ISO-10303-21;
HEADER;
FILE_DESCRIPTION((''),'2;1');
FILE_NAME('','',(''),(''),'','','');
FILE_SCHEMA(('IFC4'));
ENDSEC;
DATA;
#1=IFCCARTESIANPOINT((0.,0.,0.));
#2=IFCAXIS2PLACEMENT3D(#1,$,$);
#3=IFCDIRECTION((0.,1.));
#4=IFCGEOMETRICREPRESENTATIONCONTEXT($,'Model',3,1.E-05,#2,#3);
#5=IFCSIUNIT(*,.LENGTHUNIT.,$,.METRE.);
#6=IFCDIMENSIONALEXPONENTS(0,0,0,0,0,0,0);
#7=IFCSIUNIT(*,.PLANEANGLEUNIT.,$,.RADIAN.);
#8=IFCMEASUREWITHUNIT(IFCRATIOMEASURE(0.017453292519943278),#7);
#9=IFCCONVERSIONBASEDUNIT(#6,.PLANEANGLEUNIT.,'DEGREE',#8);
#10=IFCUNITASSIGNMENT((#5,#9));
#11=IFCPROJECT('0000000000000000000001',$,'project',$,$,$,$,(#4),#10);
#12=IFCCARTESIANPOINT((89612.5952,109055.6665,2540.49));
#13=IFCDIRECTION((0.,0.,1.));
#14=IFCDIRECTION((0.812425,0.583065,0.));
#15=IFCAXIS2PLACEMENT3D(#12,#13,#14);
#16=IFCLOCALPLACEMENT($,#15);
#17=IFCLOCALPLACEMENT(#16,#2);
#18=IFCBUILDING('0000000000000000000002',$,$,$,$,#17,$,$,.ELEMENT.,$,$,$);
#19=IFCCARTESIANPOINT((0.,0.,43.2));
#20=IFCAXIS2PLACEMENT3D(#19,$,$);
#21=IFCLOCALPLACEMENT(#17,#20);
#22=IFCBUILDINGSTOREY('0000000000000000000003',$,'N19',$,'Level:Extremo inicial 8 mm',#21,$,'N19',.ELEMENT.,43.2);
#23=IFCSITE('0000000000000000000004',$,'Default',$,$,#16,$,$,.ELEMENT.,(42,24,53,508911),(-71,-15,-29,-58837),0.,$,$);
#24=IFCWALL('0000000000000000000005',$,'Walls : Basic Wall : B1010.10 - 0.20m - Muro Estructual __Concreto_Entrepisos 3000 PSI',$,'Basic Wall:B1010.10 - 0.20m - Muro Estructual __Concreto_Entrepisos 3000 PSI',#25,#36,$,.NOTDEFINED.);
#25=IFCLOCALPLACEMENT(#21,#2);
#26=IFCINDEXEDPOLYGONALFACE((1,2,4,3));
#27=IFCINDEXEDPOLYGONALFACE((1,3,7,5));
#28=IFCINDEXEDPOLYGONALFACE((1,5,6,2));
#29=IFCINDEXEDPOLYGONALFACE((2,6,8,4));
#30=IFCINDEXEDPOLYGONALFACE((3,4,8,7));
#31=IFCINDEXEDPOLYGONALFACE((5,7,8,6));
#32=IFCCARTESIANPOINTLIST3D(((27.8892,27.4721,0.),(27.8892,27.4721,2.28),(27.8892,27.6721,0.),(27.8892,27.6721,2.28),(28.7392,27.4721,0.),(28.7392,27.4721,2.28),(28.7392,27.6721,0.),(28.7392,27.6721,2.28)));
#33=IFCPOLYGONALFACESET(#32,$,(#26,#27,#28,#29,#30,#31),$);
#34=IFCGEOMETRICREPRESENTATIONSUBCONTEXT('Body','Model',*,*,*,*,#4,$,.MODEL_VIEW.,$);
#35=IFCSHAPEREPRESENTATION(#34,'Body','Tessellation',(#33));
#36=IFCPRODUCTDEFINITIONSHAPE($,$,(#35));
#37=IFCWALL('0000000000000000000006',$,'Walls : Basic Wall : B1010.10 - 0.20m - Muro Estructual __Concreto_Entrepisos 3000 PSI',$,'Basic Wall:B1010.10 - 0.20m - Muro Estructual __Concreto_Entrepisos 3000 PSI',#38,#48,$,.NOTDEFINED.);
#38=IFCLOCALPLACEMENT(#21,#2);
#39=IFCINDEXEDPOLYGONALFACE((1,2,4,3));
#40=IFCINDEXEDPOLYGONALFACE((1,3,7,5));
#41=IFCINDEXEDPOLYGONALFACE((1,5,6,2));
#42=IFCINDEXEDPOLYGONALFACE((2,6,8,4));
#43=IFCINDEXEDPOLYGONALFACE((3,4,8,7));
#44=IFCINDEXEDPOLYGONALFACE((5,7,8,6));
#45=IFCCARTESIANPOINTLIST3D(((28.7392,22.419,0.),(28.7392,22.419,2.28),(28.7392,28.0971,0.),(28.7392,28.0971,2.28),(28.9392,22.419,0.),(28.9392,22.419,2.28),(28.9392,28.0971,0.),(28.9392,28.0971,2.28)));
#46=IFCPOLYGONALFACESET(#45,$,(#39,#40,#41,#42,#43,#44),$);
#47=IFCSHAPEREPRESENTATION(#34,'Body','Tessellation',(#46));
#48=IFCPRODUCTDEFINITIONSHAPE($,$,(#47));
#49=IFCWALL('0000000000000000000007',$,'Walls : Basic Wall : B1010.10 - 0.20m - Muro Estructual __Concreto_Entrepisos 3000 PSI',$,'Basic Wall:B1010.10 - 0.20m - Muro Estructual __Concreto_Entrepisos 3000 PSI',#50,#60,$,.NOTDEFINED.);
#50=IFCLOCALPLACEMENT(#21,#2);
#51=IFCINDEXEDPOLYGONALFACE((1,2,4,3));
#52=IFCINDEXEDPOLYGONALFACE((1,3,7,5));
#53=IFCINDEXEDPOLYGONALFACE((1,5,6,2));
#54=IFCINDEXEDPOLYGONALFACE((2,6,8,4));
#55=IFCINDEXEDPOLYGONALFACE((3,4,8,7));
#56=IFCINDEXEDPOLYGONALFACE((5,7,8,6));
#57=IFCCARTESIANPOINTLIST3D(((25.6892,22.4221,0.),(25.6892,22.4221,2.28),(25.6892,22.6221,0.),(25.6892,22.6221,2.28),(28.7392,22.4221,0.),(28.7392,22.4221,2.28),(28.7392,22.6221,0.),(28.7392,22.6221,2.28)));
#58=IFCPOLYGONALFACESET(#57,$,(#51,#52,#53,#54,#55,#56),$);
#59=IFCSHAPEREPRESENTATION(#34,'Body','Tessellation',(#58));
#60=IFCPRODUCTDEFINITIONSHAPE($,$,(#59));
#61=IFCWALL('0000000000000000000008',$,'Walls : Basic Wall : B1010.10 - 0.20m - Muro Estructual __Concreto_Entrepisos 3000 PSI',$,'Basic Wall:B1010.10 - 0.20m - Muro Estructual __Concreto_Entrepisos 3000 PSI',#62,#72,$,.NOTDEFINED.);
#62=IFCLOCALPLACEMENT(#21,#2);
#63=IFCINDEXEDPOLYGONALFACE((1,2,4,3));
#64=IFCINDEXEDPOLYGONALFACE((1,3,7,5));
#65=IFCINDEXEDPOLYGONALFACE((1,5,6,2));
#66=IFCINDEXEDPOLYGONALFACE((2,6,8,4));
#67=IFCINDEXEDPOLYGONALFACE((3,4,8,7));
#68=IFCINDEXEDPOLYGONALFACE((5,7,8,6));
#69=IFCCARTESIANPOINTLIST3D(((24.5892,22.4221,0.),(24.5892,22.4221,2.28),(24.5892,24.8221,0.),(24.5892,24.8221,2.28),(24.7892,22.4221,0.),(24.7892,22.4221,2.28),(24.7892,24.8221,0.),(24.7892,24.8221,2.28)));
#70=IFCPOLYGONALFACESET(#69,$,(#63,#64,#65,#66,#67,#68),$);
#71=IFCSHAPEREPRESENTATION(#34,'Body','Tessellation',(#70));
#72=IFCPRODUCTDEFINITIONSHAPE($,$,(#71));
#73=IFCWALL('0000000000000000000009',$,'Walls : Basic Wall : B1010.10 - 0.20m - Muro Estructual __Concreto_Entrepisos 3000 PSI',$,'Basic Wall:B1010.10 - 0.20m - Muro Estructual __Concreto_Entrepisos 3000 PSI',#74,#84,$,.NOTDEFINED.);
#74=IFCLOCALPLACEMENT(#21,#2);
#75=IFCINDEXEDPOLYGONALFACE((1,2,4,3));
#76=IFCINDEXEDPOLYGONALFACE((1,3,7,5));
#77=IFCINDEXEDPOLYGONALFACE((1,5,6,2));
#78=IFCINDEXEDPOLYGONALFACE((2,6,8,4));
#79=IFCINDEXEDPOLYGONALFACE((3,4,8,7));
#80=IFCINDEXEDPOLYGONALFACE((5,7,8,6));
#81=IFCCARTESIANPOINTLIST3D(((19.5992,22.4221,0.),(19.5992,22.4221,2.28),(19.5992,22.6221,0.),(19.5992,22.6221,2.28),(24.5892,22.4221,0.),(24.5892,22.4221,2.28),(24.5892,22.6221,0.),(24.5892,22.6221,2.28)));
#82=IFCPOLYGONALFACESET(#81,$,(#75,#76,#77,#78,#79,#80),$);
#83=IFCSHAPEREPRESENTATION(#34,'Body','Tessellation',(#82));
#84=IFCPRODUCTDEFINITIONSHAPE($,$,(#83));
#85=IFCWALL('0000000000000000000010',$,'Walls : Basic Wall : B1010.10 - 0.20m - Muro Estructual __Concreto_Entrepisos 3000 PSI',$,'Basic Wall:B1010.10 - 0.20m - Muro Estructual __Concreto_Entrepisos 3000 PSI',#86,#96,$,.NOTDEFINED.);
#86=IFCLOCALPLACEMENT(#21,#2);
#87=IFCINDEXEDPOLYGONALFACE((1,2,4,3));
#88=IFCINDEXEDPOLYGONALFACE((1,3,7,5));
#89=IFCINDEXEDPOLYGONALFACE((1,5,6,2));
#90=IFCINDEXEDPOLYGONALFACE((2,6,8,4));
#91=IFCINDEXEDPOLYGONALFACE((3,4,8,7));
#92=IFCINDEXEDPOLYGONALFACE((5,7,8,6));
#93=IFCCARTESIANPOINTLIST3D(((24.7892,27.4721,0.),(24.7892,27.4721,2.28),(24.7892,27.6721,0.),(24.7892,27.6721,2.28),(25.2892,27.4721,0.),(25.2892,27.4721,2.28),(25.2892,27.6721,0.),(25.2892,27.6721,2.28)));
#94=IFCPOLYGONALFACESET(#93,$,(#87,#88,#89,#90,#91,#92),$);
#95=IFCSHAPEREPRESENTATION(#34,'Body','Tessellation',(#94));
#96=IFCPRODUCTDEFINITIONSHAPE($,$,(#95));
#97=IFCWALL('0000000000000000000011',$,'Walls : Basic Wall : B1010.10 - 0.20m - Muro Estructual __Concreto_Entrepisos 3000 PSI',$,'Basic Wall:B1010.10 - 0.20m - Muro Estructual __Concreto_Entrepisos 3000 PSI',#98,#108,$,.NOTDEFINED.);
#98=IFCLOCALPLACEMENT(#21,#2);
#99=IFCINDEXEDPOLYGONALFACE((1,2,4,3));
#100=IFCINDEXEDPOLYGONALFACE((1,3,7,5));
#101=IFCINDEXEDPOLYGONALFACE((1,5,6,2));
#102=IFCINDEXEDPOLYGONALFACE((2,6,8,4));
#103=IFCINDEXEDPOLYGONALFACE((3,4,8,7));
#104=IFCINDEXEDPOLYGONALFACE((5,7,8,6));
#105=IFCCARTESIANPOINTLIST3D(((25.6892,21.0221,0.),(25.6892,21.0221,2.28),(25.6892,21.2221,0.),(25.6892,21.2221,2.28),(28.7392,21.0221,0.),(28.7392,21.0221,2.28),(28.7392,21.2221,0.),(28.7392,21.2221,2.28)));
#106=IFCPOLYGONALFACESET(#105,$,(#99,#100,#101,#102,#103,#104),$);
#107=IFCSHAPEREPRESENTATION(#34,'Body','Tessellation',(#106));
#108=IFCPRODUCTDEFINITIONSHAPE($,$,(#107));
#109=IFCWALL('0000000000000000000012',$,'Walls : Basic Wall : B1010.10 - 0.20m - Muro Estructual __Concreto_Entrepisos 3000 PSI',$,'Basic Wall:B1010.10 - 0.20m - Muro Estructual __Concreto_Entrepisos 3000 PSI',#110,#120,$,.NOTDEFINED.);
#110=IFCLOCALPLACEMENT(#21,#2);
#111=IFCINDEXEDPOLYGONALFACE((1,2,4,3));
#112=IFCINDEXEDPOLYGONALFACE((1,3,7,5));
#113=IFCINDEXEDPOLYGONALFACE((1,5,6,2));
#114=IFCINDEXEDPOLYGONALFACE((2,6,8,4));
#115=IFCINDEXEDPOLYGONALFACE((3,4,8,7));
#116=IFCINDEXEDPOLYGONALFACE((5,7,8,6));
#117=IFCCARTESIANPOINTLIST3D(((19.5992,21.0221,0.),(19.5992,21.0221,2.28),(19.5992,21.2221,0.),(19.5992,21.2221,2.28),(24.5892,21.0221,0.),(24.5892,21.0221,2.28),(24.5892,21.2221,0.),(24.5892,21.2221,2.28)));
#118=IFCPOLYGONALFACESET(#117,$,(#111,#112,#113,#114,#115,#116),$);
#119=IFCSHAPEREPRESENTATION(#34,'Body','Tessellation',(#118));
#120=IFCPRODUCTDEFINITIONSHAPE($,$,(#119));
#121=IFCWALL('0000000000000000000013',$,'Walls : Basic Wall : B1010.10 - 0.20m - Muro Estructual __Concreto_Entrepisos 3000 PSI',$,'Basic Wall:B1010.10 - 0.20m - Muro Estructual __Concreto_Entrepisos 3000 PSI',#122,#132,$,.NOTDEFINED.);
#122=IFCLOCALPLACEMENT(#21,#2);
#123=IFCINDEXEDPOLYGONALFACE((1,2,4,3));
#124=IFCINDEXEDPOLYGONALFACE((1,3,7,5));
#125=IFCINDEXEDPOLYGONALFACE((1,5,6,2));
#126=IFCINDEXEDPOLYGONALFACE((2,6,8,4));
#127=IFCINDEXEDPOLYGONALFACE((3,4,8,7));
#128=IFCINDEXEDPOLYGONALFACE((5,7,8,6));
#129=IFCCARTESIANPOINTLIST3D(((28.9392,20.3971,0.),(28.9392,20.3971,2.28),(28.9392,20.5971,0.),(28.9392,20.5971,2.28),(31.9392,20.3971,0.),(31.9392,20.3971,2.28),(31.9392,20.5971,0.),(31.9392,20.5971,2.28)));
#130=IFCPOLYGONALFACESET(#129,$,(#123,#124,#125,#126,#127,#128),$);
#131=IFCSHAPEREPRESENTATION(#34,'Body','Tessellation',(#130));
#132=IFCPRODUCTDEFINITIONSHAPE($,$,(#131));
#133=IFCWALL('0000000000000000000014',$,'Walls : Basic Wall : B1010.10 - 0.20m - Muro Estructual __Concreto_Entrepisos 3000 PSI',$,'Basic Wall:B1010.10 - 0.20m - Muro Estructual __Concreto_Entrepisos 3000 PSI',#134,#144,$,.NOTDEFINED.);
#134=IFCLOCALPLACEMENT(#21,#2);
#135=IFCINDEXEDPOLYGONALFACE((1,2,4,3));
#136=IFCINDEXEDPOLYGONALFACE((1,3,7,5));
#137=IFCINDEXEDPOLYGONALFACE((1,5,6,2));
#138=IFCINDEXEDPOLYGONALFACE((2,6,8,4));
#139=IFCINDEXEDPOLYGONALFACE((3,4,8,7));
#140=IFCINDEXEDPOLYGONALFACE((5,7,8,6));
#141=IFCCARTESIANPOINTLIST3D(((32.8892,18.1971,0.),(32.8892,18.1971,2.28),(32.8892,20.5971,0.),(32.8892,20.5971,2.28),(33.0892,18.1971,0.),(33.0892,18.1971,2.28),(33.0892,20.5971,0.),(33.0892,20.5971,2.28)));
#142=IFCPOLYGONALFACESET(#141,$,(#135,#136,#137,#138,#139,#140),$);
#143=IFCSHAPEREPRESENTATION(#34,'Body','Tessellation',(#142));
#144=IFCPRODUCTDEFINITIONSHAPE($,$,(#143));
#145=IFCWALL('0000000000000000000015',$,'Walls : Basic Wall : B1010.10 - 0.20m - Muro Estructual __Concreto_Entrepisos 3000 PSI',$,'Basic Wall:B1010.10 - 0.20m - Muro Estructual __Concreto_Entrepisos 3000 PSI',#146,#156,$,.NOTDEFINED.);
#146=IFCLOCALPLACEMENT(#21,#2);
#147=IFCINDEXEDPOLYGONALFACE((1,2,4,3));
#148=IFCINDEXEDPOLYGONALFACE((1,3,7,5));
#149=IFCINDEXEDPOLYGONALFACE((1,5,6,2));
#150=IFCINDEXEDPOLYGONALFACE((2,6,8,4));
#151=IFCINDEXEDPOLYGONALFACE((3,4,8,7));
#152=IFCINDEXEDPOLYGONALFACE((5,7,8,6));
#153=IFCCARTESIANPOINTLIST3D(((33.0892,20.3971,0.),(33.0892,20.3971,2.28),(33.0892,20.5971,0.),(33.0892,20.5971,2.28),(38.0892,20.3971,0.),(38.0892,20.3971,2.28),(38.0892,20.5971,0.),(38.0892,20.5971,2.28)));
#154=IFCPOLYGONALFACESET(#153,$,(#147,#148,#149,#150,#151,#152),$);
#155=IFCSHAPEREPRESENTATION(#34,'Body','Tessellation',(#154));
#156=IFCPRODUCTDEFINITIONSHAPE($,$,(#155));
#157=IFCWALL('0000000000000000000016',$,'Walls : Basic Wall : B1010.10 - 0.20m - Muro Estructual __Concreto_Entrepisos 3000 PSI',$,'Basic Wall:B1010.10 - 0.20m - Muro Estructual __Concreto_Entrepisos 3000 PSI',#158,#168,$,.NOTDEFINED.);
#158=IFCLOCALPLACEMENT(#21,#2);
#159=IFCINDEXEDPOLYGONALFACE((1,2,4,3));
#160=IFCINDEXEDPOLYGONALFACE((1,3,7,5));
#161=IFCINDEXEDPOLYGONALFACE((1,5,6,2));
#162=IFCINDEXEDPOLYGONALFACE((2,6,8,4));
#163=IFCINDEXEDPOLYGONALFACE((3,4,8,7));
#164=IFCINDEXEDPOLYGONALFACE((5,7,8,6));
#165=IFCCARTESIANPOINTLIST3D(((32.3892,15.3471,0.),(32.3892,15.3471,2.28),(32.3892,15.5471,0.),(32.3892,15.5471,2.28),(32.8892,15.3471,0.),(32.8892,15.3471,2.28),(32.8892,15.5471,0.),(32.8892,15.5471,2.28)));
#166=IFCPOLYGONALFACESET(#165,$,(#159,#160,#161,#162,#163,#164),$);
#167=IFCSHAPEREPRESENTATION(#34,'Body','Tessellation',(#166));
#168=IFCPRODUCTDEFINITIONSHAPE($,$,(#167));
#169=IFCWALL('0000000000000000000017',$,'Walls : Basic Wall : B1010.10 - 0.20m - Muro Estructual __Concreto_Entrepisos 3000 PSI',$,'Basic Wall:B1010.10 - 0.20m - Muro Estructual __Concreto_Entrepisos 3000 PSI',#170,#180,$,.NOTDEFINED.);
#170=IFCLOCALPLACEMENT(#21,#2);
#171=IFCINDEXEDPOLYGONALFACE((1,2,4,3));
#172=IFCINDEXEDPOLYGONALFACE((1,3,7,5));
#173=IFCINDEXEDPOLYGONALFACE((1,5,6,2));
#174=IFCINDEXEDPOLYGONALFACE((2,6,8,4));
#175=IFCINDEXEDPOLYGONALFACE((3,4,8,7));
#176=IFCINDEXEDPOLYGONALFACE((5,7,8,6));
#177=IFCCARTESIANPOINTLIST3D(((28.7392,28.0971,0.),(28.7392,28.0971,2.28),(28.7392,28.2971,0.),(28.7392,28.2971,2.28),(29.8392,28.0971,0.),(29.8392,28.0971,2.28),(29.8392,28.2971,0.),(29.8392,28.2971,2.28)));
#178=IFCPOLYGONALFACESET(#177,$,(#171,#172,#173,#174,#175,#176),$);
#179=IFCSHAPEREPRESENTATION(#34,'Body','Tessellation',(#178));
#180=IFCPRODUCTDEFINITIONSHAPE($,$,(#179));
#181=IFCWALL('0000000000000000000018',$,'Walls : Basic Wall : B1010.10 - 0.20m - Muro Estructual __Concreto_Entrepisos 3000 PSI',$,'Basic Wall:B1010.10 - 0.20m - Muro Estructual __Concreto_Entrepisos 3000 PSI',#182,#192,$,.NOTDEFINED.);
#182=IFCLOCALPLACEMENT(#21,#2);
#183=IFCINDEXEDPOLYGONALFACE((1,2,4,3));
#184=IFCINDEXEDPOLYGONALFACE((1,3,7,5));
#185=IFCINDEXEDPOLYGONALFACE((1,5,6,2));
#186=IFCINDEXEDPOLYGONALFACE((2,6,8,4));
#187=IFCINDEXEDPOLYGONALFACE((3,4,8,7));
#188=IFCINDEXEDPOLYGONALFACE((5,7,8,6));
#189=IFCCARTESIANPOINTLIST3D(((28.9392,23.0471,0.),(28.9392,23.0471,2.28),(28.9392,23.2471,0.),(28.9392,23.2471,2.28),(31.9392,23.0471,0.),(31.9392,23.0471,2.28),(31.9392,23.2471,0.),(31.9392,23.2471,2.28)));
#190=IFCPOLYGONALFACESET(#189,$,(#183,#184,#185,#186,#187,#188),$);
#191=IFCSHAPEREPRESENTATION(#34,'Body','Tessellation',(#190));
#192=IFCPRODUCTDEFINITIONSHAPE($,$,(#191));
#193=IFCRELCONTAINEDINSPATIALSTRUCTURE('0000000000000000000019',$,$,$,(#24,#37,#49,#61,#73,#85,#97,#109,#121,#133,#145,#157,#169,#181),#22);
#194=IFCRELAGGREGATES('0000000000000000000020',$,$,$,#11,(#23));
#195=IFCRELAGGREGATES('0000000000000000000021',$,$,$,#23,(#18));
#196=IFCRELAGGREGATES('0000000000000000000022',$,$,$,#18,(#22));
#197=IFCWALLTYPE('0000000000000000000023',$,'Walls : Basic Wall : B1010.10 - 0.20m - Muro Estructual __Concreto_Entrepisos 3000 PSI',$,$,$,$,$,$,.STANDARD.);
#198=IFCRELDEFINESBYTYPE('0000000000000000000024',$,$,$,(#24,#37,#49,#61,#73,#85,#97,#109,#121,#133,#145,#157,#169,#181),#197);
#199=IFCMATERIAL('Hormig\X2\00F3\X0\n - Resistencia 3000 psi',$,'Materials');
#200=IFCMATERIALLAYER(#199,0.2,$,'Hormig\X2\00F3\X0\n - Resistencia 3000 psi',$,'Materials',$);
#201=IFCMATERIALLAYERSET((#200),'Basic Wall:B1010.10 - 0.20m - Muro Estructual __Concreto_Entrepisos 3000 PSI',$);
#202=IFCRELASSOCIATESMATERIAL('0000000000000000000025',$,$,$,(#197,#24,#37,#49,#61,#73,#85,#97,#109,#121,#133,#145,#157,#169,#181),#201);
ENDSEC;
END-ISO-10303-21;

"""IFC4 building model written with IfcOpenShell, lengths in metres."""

from ifc_helpers import new_model, entity, si_unit, converted_unit, direction, frame, frame_2d, origin, place, context, subcontext, project, spatial, rectangle, extrude, material, layer, layer_set, layer_usage, type_object, element, save


model = new_model("IFC4")

# Units and contexts
model_context = context("Model", 3, precision=1e-05, world=origin(), true_north=direction((0.0, 1.0)))
body_context = subcontext(model_context, "Body", "Model", "MODEL_VIEW")
ifc_project = project(units=[si_unit("LENGTHUNIT", "METRE"), converted_unit("PLANEANGLEUNIT", "DEGREE", entity("IfcRatioMeasure", 0.017453292519943278), si_unit("PLANEANGLEUNIT", "RADIAN"), dimensions=[0, 0, 0, 0, 0, 0, 0])], contexts=[model_context])

# Site, building, storey
site_placement = place(None, frame((89612.5952, 109055.6665, 2540.49), z_axis=(0.0, 0.0, 1.0), x_axis=(0.812425, 0.583065, 0.0)))
site = spatial("IfcSite", under=ifc_project, at=site_placement, Name="Default", CompositionType="ELEMENT", RefLatitude=(42, 24, 53, 508911), RefLongitude=(-71, -15, -29, -58837), RefElevation=0.0)
building_placement = place(site_placement, origin())
building = spatial("IfcBuilding", under=site, at=building_placement, CompositionType="ELEMENT")
storey_placement = place(building_placement, frame((0.0, 0.0, 43.2)))
storey = spatial("IfcBuildingStorey", under=building, at=storey_placement, Name="N19", ObjectType="Level:Extremo inicial 8 mm", LongName="N19", CompositionType="ELEMENT", Elevation=43.2)

# Walls
ifc_material = material(Name="Hormigón - Resistencia 3000 psi", Category="Materials")
ifc_layer_1 = layer(ifc_material, 0.2, Name="Hormigón - Resistencia 3000 psi", Category="Materials")
ifc_layer_set_1 = layer_set([ifc_layer_1], Name="Basic Wall:B1010.10 - 0.20m - Muro Estructual __Concreto_Entrepisos 3000 PSI")
ifc_layer_usage_1 = layer_usage(ifc_layer_set_1, "AXIS2", "NEGATIVE", 0.1)
wall_type_1 = type_object("IfcWallType", Name="Walls : Basic Wall : B1010.10 - 0.20m - Muro Estructual __Concreto_Entrepisos 3000 PSI", PredefinedType="STANDARD", material=ifc_layer_set_1)
wall_1_placement = place(storey_placement, frame((27.8892, 27.5721, 0.0)))
element("IfcWall", 1, at=wall_1_placement, inside=storey, type_object=wall_type_1, material=ifc_layer_usage_1, Name="Walls : Basic Wall : B1010.10 - 0.20m - Muro Estructual __Concreto_Entrepisos 3000 PSI", ObjectType="Basic Wall:B1010.10 - 0.20m - Muro Estructual __Concreto_Entrepisos 3000 PSI", PredefinedType="NOTDEFINED", context=body_context, shape_type="SweptSolid", body=[
    extrude(rectangle(XDim=0.85, YDim=0.2, at=frame_2d((0.425, 0.0), x_axis=(-1.0, 0.0))), origin(), (0.0, 0.0, 1.0), 2.28),
])
ifc_layer_usage_2 = layer_usage(ifc_layer_set_1, "AXIS2", "NEGATIVE", 0.1)
wall_2_placement = place(storey_placement, frame((28.8392, 28.0971, 0.0), z_axis=(0.0, 0.0, 1.0), x_axis=(0.0, -1.0, 0.0)))
element("IfcWall", 2, at=wall_2_placement, inside=storey, type_object=wall_type_1, material=ifc_layer_usage_2, Name="Walls : Basic Wall : B1010.10 - 0.20m - Muro Estructual __Concreto_Entrepisos 3000 PSI", ObjectType="Basic Wall:B1010.10 - 0.20m - Muro Estructual __Concreto_Entrepisos 3000 PSI", PredefinedType="NOTDEFINED", context=body_context, shape_type="SweptSolid", body=[
    extrude(rectangle(XDim=5.6781, YDim=0.2, at=frame_2d((2.839, 0.0), x_axis=(-1.0, 0.0))), origin(), (0.0, 0.0, 1.0), 2.28),
])
ifc_layer_usage_3 = layer_usage(ifc_layer_set_1, "AXIS2", "NEGATIVE", 0.1)
wall_3_placement = place(storey_placement, frame((28.7392, 22.5221, 0.0), z_axis=(0.0, 0.0, 1.0), x_axis=(-1.0, 0.0, 0.0)))
element("IfcWall", 3, at=wall_3_placement, inside=storey, type_object=wall_type_1, material=ifc_layer_usage_3, Name="Walls : Basic Wall : B1010.10 - 0.20m - Muro Estructual __Concreto_Entrepisos 3000 PSI", ObjectType="Basic Wall:B1010.10 - 0.20m - Muro Estructual __Concreto_Entrepisos 3000 PSI", PredefinedType="NOTDEFINED", context=body_context, shape_type="SweptSolid", body=[
    extrude(rectangle(XDim=3.05, YDim=0.2, at=frame_2d((1.525, 0.0), x_axis=(-1.0, 0.0))), origin(), (0.0, 0.0, 1.0), 2.28),
])
ifc_layer_usage_4 = layer_usage(ifc_layer_set_1, "AXIS2", "NEGATIVE", 0.1)
wall_4_placement = place(storey_placement, frame((24.6892, 24.8221, 0.0), z_axis=(0.0, 0.0, 1.0), x_axis=(0.0, -1.0, 0.0)))
element("IfcWall", 4, at=wall_4_placement, inside=storey, type_object=wall_type_1, material=ifc_layer_usage_4, Name="Walls : Basic Wall : B1010.10 - 0.20m - Muro Estructual __Concreto_Entrepisos 3000 PSI", ObjectType="Basic Wall:B1010.10 - 0.20m - Muro Estructual __Concreto_Entrepisos 3000 PSI", PredefinedType="NOTDEFINED", context=body_context, shape_type="SweptSolid", body=[
    extrude(rectangle(XDim=2.4, YDim=0.2, at=frame_2d((1.2, 0.0), x_axis=(-1.0, 0.0))), origin(), (0.0, 0.0, 1.0), 2.28),
])
ifc_layer_usage_5 = layer_usage(ifc_layer_set_1, "AXIS2", "NEGATIVE", 0.1)
wall_5_placement = place(storey_placement, frame((24.5892, 22.5221, 0.0), z_axis=(0.0, 0.0, 1.0), x_axis=(-1.0, 0.0, 0.0)))
element("IfcWall", 5, at=wall_5_placement, inside=storey, type_object=wall_type_1, material=ifc_layer_usage_5, Name="Walls : Basic Wall : B1010.10 - 0.20m - Muro Estructual __Concreto_Entrepisos 3000 PSI", ObjectType="Basic Wall:B1010.10 - 0.20m - Muro Estructual __Concreto_Entrepisos 3000 PSI", PredefinedType="NOTDEFINED", context=body_context, shape_type="SweptSolid", body=[
    extrude(rectangle(XDim=4.99, YDim=0.2, at=frame_2d((2.495, 0.0), x_axis=(-1.0, 0.0))), origin(), (0.0, 0.0, 1.0), 2.28),
])
ifc_layer_usage_6 = layer_usage(ifc_layer_set_1, "AXIS2", "NEGATIVE", 0.1)
wall_6_placement = place(storey_placement, frame((25.2892, 27.5721, 0.0), z_axis=(0.0, 0.0, 1.0), x_axis=(-1.0, 0.0, 0.0)))
element("IfcWall", 6, at=wall_6_placement, inside=storey, type_object=wall_type_1, material=ifc_layer_usage_6, Name="Walls : Basic Wall : B1010.10 - 0.20m - Muro Estructual __Concreto_Entrepisos 3000 PSI", ObjectType="Basic Wall:B1010.10 - 0.20m - Muro Estructual __Concreto_Entrepisos 3000 PSI", PredefinedType="NOTDEFINED", context=body_context, shape_type="SweptSolid", body=[
    extrude(rectangle(XDim=0.5, YDim=0.2, at=frame_2d((0.25, 0.0), x_axis=(-1.0, 0.0))), origin(), (0.0, 0.0, 1.0), 2.28),
])
ifc_layer_usage_7 = layer_usage(ifc_layer_set_1, "AXIS2", "POSITIVE", -0.1)
wall_7_placement = place(storey_placement, frame((28.7392, 21.1221, 0.0), z_axis=(0.0, 0.0, 1.0), x_axis=(-1.0, 0.0, 0.0)))
element("IfcWall", 7, at=wall_7_placement, inside=storey, type_object=wall_type_1, material=ifc_layer_usage_7, Name="Walls : Basic Wall : B1010.10 - 0.20m - Muro Estructual __Concreto_Entrepisos 3000 PSI", ObjectType="Basic Wall:B1010.10 - 0.20m - Muro Estructual __Concreto_Entrepisos 3000 PSI", PredefinedType="NOTDEFINED", context=body_context, shape_type="SweptSolid", body=[
    extrude(rectangle(XDim=3.05, YDim=0.2, at=frame_2d((1.525, 0.0), x_axis=(-1.0, 0.0))), origin(), (0.0, 0.0, 1.0), 2.28),
])
ifc_layer_usage_8 = layer_usage(ifc_layer_set_1, "AXIS2", "POSITIVE", -0.1)
wall_8_placement = place(storey_placement, frame((24.5892, 21.1221, 0.0), z_axis=(0.0, 0.0, 1.0), x_axis=(-1.0, 0.0, 0.0)))
element("IfcWall", 8, at=wall_8_placement, inside=storey, type_object=wall_type_1, material=ifc_layer_usage_8, Name="Walls : Basic Wall : B1010.10 - 0.20m - Muro Estructual __Concreto_Entrepisos 3000 PSI", ObjectType="Basic Wall:B1010.10 - 0.20m - Muro Estructual __Concreto_Entrepisos 3000 PSI", PredefinedType="NOTDEFINED", context=body_context, shape_type="SweptSolid", body=[
    extrude(rectangle(XDim=4.99, YDim=0.2, at=frame_2d((2.495, 0.0), x_axis=(-1.0, 0.0))), origin(), (0.0, 0.0, 1.0), 2.28),
])
ifc_layer_usage_9 = layer_usage(ifc_layer_set_1, "AXIS2", "NEGATIVE", 0.1)
wall_9_placement = place(storey_placement, frame((28.9392, 20.4971, 0.0)))
element("IfcWall", 9, at=wall_9_placement, inside=storey, type_object=wall_type_1, material=ifc_layer_usage_9, Name="Walls : Basic Wall : B1010.10 - 0.20m - Muro Estructual __Concreto_Entrepisos 3000 PSI", ObjectType="Basic Wall:B1010.10 - 0.20m - Muro Estructual __Concreto_Entrepisos 3000 PSI", PredefinedType="NOTDEFINED", context=body_context, shape_type="SweptSolid", body=[
    extrude(rectangle(XDim=3.0, YDim=0.2, at=frame_2d((1.5, 0.0), x_axis=(-1.0, 0.0))), origin(), (0.0, 0.0, 1.0), 2.28),
])
ifc_layer_usage_10 = layer_usage(ifc_layer_set_1, "AXIS2", "NEGATIVE", 0.1)
wall_10_placement = place(storey_placement, frame((32.9892, 18.1971, 0.0), z_axis=(0.0, 0.0, 1.0), x_axis=(0.0, 1.0, 0.0)))
element("IfcWall", 10, at=wall_10_placement, inside=storey, type_object=wall_type_1, material=ifc_layer_usage_10, Name="Walls : Basic Wall : B1010.10 - 0.20m - Muro Estructual __Concreto_Entrepisos 3000 PSI", ObjectType="Basic Wall:B1010.10 - 0.20m - Muro Estructual __Concreto_Entrepisos 3000 PSI", PredefinedType="NOTDEFINED", context=body_context, shape_type="SweptSolid", body=[
    extrude(rectangle(XDim=2.4, YDim=0.2, at=frame_2d((1.2, 0.0), x_axis=(-1.0, 0.0))), origin(), (0.0, 0.0, 1.0), 2.28),
])
ifc_layer_usage_11 = layer_usage(ifc_layer_set_1, "AXIS2", "NEGATIVE", 0.1)
wall_11_placement = place(storey_placement, frame((33.0892, 20.4971, 0.0)))
element("IfcWall", 11, at=wall_11_placement, inside=storey, type_object=wall_type_1, material=ifc_layer_usage_11, Name="Walls : Basic Wall : B1010.10 - 0.20m - Muro Estructual __Concreto_Entrepisos 3000 PSI", ObjectType="Basic Wall:B1010.10 - 0.20m - Muro Estructual __Concreto_Entrepisos 3000 PSI", PredefinedType="NOTDEFINED", context=body_context, shape_type="SweptSolid", body=[
    extrude(rectangle(XDim=5.0, YDim=0.2, at=frame_2d((2.5, 0.0), x_axis=(-1.0, 0.0))), origin(), (0.0, 0.0, 1.0), 2.28),
])
ifc_layer_usage_12 = layer_usage(ifc_layer_set_1, "AXIS2", "NEGATIVE", 0.1)
wall_12_placement = place(storey_placement, frame((32.3892, 15.4471, 0.0)))
element("IfcWall", 12, at=wall_12_placement, inside=storey, type_object=wall_type_1, material=ifc_layer_usage_12, Name="Walls : Basic Wall : B1010.10 - 0.20m - Muro Estructual __Concreto_Entrepisos 3000 PSI", ObjectType="Basic Wall:B1010.10 - 0.20m - Muro Estructual __Concreto_Entrepisos 3000 PSI", PredefinedType="NOTDEFINED", context=body_context, shape_type="SweptSolid", body=[
    extrude(rectangle(XDim=0.5, YDim=0.2, at=frame_2d((0.25, 0.0), x_axis=(-1.0, 0.0))), origin(), (0.0, 0.0, 1.0), 2.28),
])
ifc_layer_usage_13 = layer_usage(ifc_layer_set_1, "AXIS2", "POSITIVE", -0.1)
wall_13_placement = place(storey_placement, frame((29.8392, 28.1971, 0.0), z_axis=(0.0, 0.0, 1.0), x_axis=(-1.0, 0.0, 0.0)))
element("IfcWall", 13, at=wall_13_placement, inside=storey, type_object=wall_type_1, material=ifc_layer_usage_13, Name="Walls : Basic Wall : B1010.10 - 0.20m - Muro Estructual __Concreto_Entrepisos 3000 PSI", ObjectType="Basic Wall:B1010.10 - 0.20m - Muro Estructual __Concreto_Entrepisos 3000 PSI", PredefinedType="NOTDEFINED", context=body_context, shape_type="SweptSolid", body=[
    extrude(rectangle(XDim=1.1, YDim=0.2, at=frame_2d((0.55, 0.0), x_axis=(-1.0, 0.0))), origin(), (0.0, 0.0, 1.0), 2.28),
])
ifc_layer_usage_14 = layer_usage(ifc_layer_set_1, "AXIS2", "POSITIVE", -0.1)
wall_14_placement = place(storey_placement, frame((28.9392, 23.1471, 0.0)))
element("IfcWall", 14, at=wall_14_placement, inside=storey, type_object=wall_type_1, material=ifc_layer_usage_14, Name="Walls : Basic Wall : B1010.10 - 0.20m - Muro Estructual __Concreto_Entrepisos 3000 PSI", ObjectType="Basic Wall:B1010.10 - 0.20m - Muro Estructual __Concreto_Entrepisos 3000 PSI", PredefinedType="NOTDEFINED", context=body_context, shape_type="SweptSolid", body=[
    extrude(rectangle(XDim=3.0, YDim=0.2, at=frame_2d((1.5, 0.0), x_axis=(-1.0, 0.0))), origin(), (0.0, 0.0, 1.0), 2.28),
])

save(model, "model.ifc")
